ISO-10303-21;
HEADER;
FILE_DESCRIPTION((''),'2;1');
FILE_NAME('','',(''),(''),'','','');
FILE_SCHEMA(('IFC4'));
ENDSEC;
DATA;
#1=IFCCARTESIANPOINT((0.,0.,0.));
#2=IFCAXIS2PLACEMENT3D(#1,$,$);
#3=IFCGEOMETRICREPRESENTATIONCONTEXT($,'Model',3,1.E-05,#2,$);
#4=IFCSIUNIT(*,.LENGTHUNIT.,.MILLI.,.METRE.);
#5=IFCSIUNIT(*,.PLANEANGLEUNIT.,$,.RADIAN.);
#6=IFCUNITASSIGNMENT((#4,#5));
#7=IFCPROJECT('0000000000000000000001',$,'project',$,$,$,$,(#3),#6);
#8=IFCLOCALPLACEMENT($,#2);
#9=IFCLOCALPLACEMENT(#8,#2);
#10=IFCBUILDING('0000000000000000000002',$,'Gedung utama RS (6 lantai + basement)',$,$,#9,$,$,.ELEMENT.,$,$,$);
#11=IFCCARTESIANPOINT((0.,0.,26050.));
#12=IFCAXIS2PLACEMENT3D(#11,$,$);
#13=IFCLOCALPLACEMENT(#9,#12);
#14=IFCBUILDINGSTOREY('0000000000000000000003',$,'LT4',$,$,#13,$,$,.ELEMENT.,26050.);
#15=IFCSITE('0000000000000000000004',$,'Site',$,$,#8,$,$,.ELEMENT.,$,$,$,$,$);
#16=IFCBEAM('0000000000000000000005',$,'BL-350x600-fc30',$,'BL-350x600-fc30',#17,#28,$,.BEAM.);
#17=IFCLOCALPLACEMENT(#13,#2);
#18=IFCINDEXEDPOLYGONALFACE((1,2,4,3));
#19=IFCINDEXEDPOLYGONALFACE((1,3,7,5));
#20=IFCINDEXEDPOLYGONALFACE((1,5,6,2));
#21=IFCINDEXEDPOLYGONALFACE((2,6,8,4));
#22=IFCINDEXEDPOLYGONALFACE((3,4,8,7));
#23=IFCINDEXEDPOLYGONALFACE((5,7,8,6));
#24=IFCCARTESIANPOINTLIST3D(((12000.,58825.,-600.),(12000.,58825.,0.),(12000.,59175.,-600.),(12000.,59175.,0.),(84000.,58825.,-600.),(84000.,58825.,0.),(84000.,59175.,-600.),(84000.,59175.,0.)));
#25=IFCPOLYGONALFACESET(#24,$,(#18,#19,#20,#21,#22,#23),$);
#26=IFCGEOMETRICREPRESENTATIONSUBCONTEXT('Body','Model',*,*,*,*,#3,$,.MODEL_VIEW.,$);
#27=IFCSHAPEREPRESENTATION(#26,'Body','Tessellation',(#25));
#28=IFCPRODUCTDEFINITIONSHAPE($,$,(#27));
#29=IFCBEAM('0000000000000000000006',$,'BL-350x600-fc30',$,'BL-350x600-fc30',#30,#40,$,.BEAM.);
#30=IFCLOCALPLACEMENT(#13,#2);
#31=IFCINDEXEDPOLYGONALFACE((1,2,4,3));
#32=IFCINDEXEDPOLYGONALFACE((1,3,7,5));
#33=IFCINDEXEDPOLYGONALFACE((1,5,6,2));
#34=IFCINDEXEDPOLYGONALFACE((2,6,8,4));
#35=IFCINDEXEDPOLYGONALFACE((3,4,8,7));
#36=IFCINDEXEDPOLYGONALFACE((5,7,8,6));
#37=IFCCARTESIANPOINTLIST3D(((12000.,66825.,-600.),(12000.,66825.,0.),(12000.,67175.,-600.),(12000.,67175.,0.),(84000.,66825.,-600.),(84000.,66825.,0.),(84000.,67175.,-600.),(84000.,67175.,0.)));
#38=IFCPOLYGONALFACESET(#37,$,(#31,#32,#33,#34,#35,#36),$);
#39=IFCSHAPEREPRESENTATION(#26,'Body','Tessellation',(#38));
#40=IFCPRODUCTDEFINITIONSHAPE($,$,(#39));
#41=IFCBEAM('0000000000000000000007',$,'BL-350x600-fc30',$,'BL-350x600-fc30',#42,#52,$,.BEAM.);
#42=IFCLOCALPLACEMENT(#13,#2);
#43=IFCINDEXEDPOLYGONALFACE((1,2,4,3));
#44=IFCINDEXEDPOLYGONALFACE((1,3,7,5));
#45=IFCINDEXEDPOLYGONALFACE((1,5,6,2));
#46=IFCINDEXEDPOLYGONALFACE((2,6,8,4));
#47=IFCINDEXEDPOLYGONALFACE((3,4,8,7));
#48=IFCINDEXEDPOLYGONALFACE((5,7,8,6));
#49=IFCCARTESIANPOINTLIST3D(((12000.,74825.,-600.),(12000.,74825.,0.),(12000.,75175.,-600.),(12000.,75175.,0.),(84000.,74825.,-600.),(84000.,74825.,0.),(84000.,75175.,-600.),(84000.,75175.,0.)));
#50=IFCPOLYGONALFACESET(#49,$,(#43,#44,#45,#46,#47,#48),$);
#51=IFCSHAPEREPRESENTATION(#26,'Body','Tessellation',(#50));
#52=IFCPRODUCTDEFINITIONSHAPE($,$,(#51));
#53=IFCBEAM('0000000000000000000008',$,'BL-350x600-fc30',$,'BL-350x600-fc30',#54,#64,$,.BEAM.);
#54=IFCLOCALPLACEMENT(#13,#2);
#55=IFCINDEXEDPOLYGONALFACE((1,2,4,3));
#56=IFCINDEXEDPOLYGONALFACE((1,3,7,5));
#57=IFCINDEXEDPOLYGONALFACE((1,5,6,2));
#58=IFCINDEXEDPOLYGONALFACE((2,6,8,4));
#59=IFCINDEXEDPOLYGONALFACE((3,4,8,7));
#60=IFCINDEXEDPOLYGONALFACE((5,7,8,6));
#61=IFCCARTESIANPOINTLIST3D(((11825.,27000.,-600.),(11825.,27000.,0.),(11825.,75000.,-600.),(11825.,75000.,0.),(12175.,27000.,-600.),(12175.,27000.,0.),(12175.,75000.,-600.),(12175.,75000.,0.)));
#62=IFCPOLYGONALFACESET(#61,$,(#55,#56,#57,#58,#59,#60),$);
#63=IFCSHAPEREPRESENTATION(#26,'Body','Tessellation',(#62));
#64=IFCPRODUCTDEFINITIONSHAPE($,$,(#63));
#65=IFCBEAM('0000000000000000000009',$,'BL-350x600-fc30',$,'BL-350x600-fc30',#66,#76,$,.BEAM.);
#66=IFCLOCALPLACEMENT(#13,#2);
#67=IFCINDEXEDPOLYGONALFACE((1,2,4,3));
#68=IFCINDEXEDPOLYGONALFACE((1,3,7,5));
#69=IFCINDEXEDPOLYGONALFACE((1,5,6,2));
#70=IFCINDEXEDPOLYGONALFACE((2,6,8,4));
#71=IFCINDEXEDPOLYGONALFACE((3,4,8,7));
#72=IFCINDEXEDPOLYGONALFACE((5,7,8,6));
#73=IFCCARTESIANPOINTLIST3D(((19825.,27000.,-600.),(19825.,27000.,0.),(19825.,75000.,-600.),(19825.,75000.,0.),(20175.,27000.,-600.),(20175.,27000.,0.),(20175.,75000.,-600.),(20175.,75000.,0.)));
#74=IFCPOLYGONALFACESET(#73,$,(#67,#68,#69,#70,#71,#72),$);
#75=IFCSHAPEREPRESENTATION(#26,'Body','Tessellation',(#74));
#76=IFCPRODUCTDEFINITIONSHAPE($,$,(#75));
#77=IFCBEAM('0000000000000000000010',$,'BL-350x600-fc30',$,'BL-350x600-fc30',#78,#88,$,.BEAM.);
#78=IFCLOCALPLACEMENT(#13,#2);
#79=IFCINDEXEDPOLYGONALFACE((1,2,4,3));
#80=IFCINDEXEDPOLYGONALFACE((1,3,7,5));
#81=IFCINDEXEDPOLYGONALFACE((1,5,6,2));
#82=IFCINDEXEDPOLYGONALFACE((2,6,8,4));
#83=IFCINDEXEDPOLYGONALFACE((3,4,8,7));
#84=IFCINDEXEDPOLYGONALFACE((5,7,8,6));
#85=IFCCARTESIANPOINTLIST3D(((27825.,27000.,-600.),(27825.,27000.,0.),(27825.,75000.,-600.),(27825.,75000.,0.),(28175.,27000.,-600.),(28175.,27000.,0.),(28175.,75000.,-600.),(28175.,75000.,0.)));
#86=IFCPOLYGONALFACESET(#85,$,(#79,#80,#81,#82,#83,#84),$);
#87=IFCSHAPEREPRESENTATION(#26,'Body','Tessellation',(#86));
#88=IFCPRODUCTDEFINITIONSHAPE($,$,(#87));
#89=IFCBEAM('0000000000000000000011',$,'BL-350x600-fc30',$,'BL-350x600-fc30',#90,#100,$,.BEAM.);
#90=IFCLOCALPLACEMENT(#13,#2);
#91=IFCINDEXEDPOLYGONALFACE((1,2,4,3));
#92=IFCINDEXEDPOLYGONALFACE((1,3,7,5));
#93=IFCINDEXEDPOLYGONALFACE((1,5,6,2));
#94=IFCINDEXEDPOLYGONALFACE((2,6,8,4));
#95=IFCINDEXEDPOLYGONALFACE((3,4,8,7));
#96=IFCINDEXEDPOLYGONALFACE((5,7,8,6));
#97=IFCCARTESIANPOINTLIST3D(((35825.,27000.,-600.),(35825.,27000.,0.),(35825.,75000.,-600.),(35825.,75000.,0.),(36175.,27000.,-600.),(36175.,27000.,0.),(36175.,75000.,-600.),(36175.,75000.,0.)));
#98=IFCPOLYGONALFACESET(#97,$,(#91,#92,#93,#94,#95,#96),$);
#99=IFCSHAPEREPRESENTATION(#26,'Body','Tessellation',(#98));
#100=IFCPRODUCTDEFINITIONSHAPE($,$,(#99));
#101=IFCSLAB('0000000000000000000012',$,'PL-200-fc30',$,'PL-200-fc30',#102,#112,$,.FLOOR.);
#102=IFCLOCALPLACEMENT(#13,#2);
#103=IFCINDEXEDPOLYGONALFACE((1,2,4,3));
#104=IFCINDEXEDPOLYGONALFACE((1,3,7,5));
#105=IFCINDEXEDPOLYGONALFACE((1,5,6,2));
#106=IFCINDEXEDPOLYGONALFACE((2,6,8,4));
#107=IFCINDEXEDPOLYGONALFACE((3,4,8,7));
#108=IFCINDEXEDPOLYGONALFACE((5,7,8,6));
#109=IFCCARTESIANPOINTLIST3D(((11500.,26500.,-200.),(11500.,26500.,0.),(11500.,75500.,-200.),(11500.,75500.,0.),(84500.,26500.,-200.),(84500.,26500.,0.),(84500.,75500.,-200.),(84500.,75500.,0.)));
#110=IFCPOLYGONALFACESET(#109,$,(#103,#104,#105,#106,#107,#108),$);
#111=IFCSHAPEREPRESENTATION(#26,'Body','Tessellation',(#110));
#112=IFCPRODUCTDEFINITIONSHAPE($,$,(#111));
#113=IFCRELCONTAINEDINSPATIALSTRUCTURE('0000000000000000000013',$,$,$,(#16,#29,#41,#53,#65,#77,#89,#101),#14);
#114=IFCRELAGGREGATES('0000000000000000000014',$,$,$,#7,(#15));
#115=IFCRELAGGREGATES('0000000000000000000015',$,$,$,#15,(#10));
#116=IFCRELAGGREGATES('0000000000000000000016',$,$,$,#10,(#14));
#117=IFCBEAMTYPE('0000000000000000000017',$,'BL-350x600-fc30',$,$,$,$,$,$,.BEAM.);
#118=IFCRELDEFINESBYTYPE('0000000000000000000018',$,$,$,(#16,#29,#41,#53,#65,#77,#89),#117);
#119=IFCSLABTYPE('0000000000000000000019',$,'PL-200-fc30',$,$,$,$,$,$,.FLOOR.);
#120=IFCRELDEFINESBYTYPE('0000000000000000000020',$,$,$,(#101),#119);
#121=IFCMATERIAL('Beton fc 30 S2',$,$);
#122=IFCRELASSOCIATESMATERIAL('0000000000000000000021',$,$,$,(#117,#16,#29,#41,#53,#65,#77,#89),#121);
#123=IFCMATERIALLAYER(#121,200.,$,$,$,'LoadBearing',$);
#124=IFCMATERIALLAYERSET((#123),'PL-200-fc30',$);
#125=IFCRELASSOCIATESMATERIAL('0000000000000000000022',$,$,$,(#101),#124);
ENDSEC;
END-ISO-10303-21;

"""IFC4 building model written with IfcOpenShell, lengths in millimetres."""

from ifc_helpers import new_model, si_unit, frame, origin, origin_2d, place, context, subcontext, project, spatial, polyline, rectangle, outline, extrude, material, layer, layer_set, layer_usage, material_profile, profile_set, profile_usage, type_object, element, save


model = new_model("IFC4")

# Units and contexts
model_context = context("Model", 3, precision=1e-05, world=origin())
body_context = subcontext(model_context, "Body", "Model", "MODEL_VIEW")
ifc_project = project(units=[si_unit("LENGTHUNIT", "METRE", prefix="MILLI"), si_unit("PLANEANGLEUNIT", "RADIAN")], contexts=[model_context])

# Site, building, storey
site_placement = place(None, origin())
site = spatial("IfcSite", under=ifc_project, at=site_placement, Name="Site", CompositionType="ELEMENT")
building_placement = place(site_placement, origin())
building = spatial("IfcBuilding", under=site, at=building_placement, Name="Gedung utama RS (6 lantai + basement)", CompositionType="ELEMENT")
storey_placement = place(building_placement, frame((0.0, 0.0, 26050.0)))
storey = spatial("IfcBuildingStorey", under=building, at=storey_placement, Name="LT4", CompositionType="ELEMENT", Elevation=26050.0)

# Beams
ifc_material = material(Name="Beton fc 30 S2")
ifc_material_profile_1 = material_profile(ifc_material, rectangle(XDim=350.0, YDim=600.0, at=origin_2d()), Name="BL-350x600-fc30")
ifc_profile_set_1 = profile_set([ifc_material_profile_1], Name="BL-350x600-fc30")
ifc_profile_usage_1 = profile_usage(ifc_profile_set_1, cardinal=8)
beam_type = type_object("IfcBeamType", Name="BL-350x600-fc30", PredefinedType="BEAM", material=ifc_profile_set_1)
for number, where, name in (
    (1, (12000.0, 59000.0, -300.0), "BL-350x600-fc30"),
    (2, (12000.0, 67000.0, -300.0), "BL-350x600-fc30"),
    (3, (12000.0, 75000.0, -300.0), "BL-350x600-fc30"),
):
    element("IfcBeam", number, at=place(storey_placement, frame(where)), inside=storey, type_object=beam_type, material=ifc_profile_usage_1, Name=name, ObjectType="BL-350x600-fc30", PredefinedType="BEAM", context=body_context, shape_type="SweptSolid", body=[
        extrude(rectangle(XDim=350.0, YDim=600.0, at=origin_2d()), frame((0.0, 0.0, 0.0), z_axis=(1.0, 0.0, 0.0), x_axis=(0.0, 1.0, 0.0)), (0.0, 0.0, 1.0), 72000.0),
    ])
for number, where, name in (
    (4, (12000.0, 27000.0, -300.0), "BL-350x600-fc30"),
    (5, (20000.0, 27000.0, -300.0), "BL-350x600-fc30"),
    (6, (28000.0, 27000.0, -300.0), "BL-350x600-fc30"),
    (7, (36000.0, 27000.0, -300.0), "BL-350x600-fc30"),
):
    element("IfcBeam", number, at=place(storey_placement, frame(where)), inside=storey, type_object=beam_type, material=ifc_profile_usage_1, Name=name, ObjectType="BL-350x600-fc30", PredefinedType="BEAM", context=body_context, shape_type="SweptSolid", body=[
        extrude(rectangle(XDim=350.0, YDim=600.0, at=origin_2d()), frame((0.0, 0.0, 0.0), z_axis=(0.0, 1.0, 0.0), x_axis=(-1.0, 0.0, 0.0)), (0.0, 0.0, 1.0), 48000.0),
    ])

# Slab
ifc_layer = layer(ifc_material, 200.0, Category="LoadBearing")
ifc_layer_set = layer_set([ifc_layer], Name="PL-200-fc30")
ifc_layer_usage = layer_usage(ifc_layer_set, "AXIS3", "NEGATIVE", 0.0)
slab_type = type_object("IfcSlabType", Name="PL-200-fc30", PredefinedType="FLOOR")
slab_placement = place(storey_placement, origin())
element("IfcSlab", 8, at=slab_placement, inside=storey, type_object=slab_type, material=ifc_layer_usage, Name="PL-200-fc30", ObjectType="PL-200-fc30", PredefinedType="FLOOR", context=body_context, shape_type="SweptSolid", body=[
    extrude(outline(polyline([(11500.0, 26500.0), (84500.0, 26500.0), (84500.0, 75500.0), (11500.0, 75500.0), (11500.0, 26500.0)])), frame((0.0, 0.0, -200.0)), (0.0, 0.0, 1.0), 200.0),
])

save(model, "model.ifc")
